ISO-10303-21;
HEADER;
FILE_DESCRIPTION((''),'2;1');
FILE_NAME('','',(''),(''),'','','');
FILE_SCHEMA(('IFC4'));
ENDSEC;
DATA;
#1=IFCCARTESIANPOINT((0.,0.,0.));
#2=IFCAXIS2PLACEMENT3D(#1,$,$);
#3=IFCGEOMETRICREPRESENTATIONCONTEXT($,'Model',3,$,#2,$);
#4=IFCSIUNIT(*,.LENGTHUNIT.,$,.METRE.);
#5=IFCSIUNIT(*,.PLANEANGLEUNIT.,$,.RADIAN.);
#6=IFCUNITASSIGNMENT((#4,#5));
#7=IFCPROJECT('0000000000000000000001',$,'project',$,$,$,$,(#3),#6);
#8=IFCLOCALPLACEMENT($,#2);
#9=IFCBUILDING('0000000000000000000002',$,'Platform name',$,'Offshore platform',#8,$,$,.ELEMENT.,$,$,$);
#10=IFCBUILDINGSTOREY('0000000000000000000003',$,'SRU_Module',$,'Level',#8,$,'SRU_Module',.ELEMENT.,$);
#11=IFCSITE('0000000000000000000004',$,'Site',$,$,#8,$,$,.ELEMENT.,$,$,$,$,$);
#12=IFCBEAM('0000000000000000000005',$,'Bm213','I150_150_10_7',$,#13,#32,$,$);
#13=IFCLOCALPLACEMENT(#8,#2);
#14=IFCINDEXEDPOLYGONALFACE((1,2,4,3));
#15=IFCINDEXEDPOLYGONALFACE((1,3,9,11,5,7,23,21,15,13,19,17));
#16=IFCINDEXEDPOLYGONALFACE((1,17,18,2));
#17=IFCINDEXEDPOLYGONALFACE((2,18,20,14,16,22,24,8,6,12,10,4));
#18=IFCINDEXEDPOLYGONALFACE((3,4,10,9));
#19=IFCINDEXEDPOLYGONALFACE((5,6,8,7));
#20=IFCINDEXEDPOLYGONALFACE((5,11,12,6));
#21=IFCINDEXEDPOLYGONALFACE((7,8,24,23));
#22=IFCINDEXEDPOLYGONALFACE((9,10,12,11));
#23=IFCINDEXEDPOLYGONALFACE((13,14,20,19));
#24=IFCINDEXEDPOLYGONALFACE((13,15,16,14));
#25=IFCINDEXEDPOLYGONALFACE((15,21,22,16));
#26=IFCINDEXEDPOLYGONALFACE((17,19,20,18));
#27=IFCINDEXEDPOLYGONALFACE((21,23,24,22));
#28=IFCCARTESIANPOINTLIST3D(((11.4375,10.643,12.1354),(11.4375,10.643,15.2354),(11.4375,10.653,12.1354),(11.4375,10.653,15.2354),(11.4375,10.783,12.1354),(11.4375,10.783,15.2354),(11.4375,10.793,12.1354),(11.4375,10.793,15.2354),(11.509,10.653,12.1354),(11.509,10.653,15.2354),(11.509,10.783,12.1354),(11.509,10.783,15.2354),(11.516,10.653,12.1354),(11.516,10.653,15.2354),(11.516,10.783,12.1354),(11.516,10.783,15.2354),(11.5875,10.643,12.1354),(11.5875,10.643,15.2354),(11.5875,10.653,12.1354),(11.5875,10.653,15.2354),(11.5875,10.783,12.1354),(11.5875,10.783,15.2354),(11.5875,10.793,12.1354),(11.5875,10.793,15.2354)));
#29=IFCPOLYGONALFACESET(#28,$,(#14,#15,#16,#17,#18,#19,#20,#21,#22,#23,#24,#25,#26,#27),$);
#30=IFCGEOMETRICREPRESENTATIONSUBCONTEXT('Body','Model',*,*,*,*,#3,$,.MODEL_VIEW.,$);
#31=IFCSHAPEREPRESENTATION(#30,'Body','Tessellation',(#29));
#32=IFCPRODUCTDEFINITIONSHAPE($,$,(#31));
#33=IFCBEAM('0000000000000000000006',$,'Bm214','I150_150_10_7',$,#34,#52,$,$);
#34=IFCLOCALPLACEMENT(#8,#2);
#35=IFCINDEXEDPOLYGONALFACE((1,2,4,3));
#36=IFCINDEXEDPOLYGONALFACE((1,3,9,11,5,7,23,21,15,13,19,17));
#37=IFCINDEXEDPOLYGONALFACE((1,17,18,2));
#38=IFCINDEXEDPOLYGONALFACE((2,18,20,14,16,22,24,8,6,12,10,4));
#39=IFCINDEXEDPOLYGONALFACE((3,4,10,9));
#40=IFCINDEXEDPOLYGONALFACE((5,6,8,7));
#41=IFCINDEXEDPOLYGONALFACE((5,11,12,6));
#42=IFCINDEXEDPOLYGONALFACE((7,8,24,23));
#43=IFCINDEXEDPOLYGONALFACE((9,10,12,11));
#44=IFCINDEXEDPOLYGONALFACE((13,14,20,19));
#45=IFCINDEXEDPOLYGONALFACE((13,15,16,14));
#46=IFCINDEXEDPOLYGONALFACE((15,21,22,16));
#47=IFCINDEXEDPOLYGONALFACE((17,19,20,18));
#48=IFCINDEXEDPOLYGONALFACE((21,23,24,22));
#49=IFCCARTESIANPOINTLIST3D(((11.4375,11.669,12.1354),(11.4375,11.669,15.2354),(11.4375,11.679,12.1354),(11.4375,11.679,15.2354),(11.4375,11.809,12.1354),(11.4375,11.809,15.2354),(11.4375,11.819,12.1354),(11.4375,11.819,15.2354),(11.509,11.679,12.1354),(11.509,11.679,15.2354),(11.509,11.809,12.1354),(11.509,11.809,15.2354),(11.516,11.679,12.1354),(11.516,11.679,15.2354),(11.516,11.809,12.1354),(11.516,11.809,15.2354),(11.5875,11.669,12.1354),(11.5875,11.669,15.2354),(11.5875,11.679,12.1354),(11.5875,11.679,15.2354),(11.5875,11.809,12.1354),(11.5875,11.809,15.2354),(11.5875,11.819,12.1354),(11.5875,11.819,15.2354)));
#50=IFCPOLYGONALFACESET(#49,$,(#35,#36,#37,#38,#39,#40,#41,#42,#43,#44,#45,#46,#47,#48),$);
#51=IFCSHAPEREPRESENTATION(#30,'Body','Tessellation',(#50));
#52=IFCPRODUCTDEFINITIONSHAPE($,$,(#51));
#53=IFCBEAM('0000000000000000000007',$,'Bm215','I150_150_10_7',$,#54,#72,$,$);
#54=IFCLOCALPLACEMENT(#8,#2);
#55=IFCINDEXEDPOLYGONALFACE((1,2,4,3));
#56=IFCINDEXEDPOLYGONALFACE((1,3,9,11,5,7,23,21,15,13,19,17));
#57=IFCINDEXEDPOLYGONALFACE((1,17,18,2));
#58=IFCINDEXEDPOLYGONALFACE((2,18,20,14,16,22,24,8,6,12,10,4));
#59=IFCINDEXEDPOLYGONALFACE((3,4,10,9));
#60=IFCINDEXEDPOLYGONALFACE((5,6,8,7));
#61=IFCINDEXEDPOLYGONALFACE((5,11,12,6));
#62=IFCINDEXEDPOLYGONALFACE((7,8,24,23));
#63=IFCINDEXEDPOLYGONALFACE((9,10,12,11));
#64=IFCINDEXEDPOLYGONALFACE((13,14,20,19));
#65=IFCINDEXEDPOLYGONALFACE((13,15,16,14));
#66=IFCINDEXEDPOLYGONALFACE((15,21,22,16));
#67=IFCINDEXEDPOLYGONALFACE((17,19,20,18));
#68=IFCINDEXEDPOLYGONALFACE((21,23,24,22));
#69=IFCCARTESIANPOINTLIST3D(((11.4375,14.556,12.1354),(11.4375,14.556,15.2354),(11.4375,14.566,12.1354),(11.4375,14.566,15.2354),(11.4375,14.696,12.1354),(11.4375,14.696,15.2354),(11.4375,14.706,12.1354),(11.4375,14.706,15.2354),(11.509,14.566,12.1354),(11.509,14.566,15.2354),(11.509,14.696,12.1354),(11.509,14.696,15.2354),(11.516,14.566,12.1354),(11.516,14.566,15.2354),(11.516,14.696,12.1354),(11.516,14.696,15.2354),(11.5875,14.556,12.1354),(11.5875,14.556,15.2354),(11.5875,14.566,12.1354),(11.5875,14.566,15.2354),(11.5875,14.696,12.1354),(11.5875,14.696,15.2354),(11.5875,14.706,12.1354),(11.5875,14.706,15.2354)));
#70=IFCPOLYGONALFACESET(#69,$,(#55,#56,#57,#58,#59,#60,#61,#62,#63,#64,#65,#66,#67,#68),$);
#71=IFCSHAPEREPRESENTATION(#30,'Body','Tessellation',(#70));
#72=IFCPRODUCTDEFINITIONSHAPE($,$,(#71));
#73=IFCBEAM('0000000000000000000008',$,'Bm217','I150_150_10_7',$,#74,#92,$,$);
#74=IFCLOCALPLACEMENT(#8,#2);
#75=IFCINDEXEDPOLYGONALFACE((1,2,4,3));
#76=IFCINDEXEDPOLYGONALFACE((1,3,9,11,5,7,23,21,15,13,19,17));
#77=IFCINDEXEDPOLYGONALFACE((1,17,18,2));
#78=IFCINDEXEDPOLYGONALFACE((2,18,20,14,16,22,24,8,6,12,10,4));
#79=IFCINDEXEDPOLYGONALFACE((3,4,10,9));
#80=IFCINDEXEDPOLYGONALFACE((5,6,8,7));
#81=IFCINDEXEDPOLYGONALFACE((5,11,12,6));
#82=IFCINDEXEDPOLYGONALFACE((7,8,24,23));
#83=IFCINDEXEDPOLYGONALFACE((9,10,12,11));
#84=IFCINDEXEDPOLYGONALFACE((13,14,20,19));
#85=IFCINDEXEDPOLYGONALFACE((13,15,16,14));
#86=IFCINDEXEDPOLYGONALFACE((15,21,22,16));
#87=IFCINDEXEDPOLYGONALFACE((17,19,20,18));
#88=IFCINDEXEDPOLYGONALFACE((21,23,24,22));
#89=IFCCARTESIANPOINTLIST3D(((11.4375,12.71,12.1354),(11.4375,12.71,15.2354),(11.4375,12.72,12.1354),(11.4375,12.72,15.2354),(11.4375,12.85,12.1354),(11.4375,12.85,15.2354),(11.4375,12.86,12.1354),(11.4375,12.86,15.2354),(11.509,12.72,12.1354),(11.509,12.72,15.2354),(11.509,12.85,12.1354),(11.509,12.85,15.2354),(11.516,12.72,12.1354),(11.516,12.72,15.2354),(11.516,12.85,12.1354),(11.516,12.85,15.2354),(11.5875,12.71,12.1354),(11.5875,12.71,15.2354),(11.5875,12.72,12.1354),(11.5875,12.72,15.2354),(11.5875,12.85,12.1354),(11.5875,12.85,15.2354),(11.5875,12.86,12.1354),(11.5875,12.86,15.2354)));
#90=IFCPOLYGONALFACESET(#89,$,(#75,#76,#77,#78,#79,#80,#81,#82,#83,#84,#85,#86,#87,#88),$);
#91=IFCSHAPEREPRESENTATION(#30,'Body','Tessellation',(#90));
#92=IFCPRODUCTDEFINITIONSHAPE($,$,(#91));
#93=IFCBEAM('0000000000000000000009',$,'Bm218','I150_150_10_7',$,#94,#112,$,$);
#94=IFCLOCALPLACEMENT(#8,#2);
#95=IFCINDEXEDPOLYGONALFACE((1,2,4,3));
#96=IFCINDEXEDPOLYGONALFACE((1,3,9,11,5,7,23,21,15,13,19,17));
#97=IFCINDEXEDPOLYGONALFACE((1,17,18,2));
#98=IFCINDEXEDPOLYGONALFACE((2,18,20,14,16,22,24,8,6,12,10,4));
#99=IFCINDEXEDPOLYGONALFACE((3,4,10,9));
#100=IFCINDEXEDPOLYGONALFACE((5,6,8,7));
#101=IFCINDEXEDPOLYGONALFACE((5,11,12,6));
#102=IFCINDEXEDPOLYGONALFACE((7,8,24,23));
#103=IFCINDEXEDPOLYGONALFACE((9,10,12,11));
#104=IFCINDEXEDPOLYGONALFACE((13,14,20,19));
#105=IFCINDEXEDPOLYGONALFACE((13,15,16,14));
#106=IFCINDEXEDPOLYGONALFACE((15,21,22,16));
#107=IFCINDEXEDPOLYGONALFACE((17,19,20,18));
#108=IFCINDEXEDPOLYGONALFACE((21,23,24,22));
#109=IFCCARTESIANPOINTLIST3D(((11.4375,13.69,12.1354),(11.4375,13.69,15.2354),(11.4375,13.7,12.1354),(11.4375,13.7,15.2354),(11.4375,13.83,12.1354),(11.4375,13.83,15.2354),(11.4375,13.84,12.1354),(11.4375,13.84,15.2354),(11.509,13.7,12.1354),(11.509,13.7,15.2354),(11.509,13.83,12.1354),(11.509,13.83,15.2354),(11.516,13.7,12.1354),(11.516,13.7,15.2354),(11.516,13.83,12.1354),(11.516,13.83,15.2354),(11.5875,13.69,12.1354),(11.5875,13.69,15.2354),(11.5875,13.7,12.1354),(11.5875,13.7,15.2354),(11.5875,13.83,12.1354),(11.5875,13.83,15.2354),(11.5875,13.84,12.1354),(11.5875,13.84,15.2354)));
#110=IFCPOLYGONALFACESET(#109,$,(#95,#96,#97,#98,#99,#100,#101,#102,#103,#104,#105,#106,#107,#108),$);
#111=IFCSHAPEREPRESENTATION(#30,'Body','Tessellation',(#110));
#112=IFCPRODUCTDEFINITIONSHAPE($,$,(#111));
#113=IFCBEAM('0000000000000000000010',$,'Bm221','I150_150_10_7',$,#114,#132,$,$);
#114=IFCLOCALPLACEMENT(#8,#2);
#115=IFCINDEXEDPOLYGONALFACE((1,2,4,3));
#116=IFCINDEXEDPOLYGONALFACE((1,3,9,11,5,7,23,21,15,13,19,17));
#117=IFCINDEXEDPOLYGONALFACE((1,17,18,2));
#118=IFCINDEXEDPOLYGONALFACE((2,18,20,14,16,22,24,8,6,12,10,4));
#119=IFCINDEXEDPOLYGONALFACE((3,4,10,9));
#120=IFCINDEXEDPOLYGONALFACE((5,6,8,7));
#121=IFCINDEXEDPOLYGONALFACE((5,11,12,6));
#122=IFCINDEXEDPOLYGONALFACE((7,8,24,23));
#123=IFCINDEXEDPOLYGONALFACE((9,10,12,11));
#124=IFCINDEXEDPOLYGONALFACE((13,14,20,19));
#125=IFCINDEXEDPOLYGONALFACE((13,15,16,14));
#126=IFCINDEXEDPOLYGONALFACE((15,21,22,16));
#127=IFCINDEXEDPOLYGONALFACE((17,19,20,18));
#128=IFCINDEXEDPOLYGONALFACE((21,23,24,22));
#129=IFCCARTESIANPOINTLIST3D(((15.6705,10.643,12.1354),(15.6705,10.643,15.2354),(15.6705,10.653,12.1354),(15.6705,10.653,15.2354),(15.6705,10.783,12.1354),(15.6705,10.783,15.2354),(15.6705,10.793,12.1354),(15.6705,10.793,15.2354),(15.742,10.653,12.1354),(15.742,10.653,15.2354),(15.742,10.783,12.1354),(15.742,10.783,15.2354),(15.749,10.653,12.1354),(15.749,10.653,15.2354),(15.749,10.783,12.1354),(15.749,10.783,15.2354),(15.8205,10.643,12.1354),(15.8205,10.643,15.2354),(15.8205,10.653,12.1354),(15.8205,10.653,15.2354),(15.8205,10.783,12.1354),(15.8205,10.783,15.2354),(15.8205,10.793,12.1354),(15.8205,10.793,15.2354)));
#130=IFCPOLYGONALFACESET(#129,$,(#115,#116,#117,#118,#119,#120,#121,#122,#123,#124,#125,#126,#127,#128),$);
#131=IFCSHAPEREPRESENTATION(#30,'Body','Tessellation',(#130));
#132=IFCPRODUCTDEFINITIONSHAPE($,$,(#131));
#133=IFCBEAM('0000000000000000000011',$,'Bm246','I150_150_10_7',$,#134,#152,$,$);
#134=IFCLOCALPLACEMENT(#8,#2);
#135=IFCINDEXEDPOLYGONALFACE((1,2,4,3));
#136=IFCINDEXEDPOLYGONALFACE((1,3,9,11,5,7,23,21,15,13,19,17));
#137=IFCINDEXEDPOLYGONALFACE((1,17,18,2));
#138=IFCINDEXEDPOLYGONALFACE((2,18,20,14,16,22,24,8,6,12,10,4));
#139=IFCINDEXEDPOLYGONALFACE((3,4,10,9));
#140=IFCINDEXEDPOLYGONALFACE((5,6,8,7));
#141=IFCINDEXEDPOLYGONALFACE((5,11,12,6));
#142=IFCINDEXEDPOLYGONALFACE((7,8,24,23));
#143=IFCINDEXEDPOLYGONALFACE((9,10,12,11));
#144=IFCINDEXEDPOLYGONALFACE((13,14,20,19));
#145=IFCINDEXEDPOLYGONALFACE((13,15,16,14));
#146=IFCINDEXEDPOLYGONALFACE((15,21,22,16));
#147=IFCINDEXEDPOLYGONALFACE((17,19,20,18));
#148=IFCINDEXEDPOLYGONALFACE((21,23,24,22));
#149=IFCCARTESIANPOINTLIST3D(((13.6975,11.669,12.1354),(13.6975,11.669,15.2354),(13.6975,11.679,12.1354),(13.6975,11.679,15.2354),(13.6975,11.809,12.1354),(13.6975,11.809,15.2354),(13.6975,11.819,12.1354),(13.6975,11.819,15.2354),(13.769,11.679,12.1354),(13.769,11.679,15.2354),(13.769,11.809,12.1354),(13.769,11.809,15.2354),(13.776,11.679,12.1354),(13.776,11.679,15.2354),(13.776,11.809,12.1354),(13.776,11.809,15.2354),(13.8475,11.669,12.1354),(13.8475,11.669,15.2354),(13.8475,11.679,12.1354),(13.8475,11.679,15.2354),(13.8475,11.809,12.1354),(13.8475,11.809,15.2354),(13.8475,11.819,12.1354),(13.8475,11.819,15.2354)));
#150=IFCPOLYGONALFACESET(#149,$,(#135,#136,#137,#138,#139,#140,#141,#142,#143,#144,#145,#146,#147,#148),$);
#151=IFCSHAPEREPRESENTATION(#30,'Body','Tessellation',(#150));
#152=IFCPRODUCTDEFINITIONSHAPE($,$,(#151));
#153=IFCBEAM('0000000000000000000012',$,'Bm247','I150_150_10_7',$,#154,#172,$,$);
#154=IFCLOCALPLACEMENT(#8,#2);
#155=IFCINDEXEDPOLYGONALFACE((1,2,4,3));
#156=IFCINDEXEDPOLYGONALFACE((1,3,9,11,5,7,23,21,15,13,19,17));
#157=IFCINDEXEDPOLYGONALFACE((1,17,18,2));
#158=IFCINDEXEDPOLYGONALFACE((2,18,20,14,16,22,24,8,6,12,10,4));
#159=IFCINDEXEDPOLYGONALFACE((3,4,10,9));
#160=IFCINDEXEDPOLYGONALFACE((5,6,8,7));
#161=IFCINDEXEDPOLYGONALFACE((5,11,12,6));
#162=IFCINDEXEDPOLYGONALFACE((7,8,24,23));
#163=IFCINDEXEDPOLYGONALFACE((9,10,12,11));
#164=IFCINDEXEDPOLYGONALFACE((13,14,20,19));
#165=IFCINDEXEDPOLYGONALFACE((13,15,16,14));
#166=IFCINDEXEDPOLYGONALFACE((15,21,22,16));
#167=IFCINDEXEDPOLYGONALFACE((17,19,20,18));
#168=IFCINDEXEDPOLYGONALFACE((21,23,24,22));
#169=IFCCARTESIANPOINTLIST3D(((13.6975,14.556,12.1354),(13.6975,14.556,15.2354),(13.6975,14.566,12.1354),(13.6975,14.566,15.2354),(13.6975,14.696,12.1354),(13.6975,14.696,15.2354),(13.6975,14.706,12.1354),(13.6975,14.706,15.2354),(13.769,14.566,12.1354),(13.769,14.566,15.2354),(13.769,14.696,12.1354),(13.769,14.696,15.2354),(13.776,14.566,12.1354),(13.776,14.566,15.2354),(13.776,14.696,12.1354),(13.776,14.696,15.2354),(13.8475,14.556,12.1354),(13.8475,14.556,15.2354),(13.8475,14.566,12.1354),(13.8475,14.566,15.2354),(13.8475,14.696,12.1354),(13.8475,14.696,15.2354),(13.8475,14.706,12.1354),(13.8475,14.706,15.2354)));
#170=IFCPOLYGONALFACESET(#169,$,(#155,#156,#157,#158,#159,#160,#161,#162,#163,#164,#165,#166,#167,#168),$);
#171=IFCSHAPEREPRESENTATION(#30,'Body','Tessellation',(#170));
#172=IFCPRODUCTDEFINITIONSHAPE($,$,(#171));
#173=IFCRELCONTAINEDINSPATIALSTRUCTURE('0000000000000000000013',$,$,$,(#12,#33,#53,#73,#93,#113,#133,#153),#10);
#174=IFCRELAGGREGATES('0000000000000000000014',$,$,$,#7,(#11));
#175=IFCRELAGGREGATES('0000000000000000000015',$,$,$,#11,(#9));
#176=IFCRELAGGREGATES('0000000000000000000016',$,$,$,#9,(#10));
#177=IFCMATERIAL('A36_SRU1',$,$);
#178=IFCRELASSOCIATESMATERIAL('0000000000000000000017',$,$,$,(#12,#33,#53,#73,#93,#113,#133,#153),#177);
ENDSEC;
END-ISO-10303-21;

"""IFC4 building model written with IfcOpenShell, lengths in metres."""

from ifc_helpers import new_model, si_unit, frame, origin, origin_with_axes, origin_2d, place, context, subcontext, project, spatial, i_section, extrude, source, transform, mapped, material, element, save


model = new_model("IFC4")

# Units and contexts
model_context = context("Model", 3, world=origin())
body_context = subcontext(model_context, "Body", "Model", "MODEL_VIEW")
ifc_project = project(units=[si_unit("LENGTHUNIT", "METRE"), si_unit("PLANEANGLEUNIT", "RADIAN")], contexts=[model_context])

# Site, building, storey
placement_1 = place(None, origin())
site = spatial("IfcSite", under=ifc_project, at=placement_1, Name="Site", CompositionType="ELEMENT")
building = spatial("IfcBuilding", under=site, at=placement_1, Name="Platform name", ObjectType="Offshore platform", CompositionType="ELEMENT")
storey = spatial("IfcBuildingStorey", under=building, at=placement_1, Name="SRU_Module", ObjectType="Level", LongName="SRU_Module", CompositionType="ELEMENT")

# Beams
ifc_material = material(Name="A36_SRU1")
shared_shape_1 = source(origin(), body_context, "Body", "SweptSolid", [
    extrude(i_section(OverallWidth=0.15, OverallDepth=0.15, WebThickness=0.007, FlangeThickness=0.01, FilletRadius=0.0, at=origin_2d()), origin_with_axes(), (0.0, 0.0, 1.0), 3.1),
])
placement_2 = place(None, origin())
placement_3 = place(placement_2, origin())
placement_4 = place(placement_3, origin())
beam_1_placement = place(placement_4, frame((11.5125, 10.718, 12.1354)))
element("IfcBeam", 1, at=beam_1_placement, inside=storey, material=ifc_material, Name="Bm213", Description="I150_150_10_7", context=body_context, shape_type="MappedRepresentation", body=[
    mapped(shared_shape_1, transform((0.0, 0.0, 0.0), scale=1.0)),
])
shared_shape_2 = source(origin(), body_context, "Body", "SweptSolid", [
    extrude(i_section(OverallWidth=0.15, OverallDepth=0.15, WebThickness=0.007, FlangeThickness=0.01, FilletRadius=0.0, at=origin_2d()), origin_with_axes(), (0.0, 0.0, 1.0), 3.1),
])
placement_5 = place(None, origin())
placement_6 = place(placement_5, origin())
placement_7 = place(placement_6, origin())
beam_2_placement = place(placement_7, frame((11.5125, 11.744, 12.1354)))
element("IfcBeam", 2, at=beam_2_placement, inside=storey, material=ifc_material, Name="Bm214", Description="I150_150_10_7", context=body_context, shape_type="MappedRepresentation", body=[
    mapped(shared_shape_2, transform((0.0, 0.0, 0.0), scale=1.0)),
])
shared_shape_3 = source(origin(), body_context, "Body", "SweptSolid", [
    extrude(i_section(OverallWidth=0.15, OverallDepth=0.15, WebThickness=0.007, FlangeThickness=0.01, FilletRadius=0.0, at=origin_2d()), origin_with_axes(), (0.0, 0.0, 1.0), 3.1),
])
placement_8 = place(None, origin())
placement_9 = place(placement_8, origin())
placement_10 = place(placement_9, origin())
beam_3_placement = place(placement_10, frame((11.5125, 14.631, 12.1354)))
element("IfcBeam", 3, at=beam_3_placement, inside=storey, material=ifc_material, Name="Bm215", Description="I150_150_10_7", context=body_context, shape_type="MappedRepresentation", body=[
    mapped(shared_shape_3, transform((0.0, 0.0, 0.0), scale=1.0)),
])
shared_shape_4 = source(origin(), body_context, "Body", "SweptSolid", [
    extrude(i_section(OverallWidth=0.15, OverallDepth=0.15, WebThickness=0.007, FlangeThickness=0.01, FilletRadius=0.0, at=origin_2d()), origin_with_axes(), (0.0, 0.0, 1.0), 3.1),
])
placement_11 = place(None, origin())
placement_12 = place(placement_11, origin())
placement_13 = place(placement_12, origin())
beam_4_placement = place(placement_13, frame((11.5125, 12.785, 12.1354)))
element("IfcBeam", 4, at=beam_4_placement, inside=storey, material=ifc_material, Name="Bm217", Description="I150_150_10_7", context=body_context, shape_type="MappedRepresentation", body=[
    mapped(shared_shape_4, transform((0.0, 0.0, 0.0), scale=1.0)),
])
shared_shape_5 = source(origin(), body_context, "Body", "SweptSolid", [
    extrude(i_section(OverallWidth=0.15, OverallDepth=0.15, WebThickness=0.007, FlangeThickness=0.01, FilletRadius=0.0, at=origin_2d()), origin_with_axes(), (0.0, 0.0, 1.0), 3.1),
])
placement_14 = place(None, origin())
placement_15 = place(placement_14, origin())
placement_16 = place(placement_15, origin())
beam_5_placement = place(placement_16, frame((11.5125, 13.765, 12.1354)))
element("IfcBeam", 5, at=beam_5_placement, inside=storey, material=ifc_material, Name="Bm218", Description="I150_150_10_7", context=body_context, shape_type="MappedRepresentation", body=[
    mapped(shared_shape_5, transform((0.0, 0.0, 0.0), scale=1.0)),
])
shared_shape_6 = source(origin(), body_context, "Body", "SweptSolid", [
    extrude(i_section(OverallWidth=0.15, OverallDepth=0.15, WebThickness=0.007, FlangeThickness=0.01, FilletRadius=0.0, at=origin_2d()), origin_with_axes(), (0.0, 0.0, 1.0), 3.1),
])
placement_17 = place(None, origin())
placement_18 = place(placement_17, origin())
placement_19 = place(placement_18, origin())
beam_6_placement = place(placement_19, frame((15.7455, 10.718, 12.1354)))
element("IfcBeam", 6, at=beam_6_placement, inside=storey, material=ifc_material, Name="Bm221", Description="I150_150_10_7", context=body_context, shape_type="MappedRepresentation", body=[
    mapped(shared_shape_6, transform((0.0, 0.0, 0.0), scale=1.0)),
])
shared_shape_7 = source(origin(), body_context, "Body", "SweptSolid", [
    extrude(i_section(OverallWidth=0.15, OverallDepth=0.15, WebThickness=0.007, FlangeThickness=0.01, FilletRadius=0.0, at=origin_2d()), origin_with_axes(), (0.0, 0.0, 1.0), 3.1),
])
placement_20 = place(None, origin())
placement_21 = place(placement_20, origin())
placement_22 = place(placement_21, origin())
beam_7_placement = place(placement_22, frame((13.7725, 11.744, 12.1354)))
element("IfcBeam", 7, at=beam_7_placement, inside=storey, material=ifc_material, Name="Bm246", Description="I150_150_10_7", context=body_context, shape_type="MappedRepresentation", body=[
    mapped(shared_shape_7, transform((0.0, 0.0, 0.0), scale=1.0)),
])
shared_shape_8 = source(origin(), body_context, "Body", "SweptSolid", [
    extrude(i_section(OverallWidth=0.15, OverallDepth=0.15, WebThickness=0.007, FlangeThickness=0.01, FilletRadius=0.0, at=origin_2d()), origin_with_axes(), (0.0, 0.0, 1.0), 3.1),
])
placement_23 = place(None, origin())
placement_24 = place(placement_23, origin())
placement_25 = place(placement_24, origin())
beam_8_placement = place(placement_25, frame((13.7725, 14.631, 12.1354)))
element("IfcBeam", 8, at=beam_8_placement, inside=storey, material=ifc_material, Name="Bm247", Description="I150_150_10_7", context=body_context, shape_type="MappedRepresentation", body=[
    mapped(shared_shape_8, transform((0.0, 0.0, 0.0), scale=1.0)),
])

save(model, "model.ifc")
